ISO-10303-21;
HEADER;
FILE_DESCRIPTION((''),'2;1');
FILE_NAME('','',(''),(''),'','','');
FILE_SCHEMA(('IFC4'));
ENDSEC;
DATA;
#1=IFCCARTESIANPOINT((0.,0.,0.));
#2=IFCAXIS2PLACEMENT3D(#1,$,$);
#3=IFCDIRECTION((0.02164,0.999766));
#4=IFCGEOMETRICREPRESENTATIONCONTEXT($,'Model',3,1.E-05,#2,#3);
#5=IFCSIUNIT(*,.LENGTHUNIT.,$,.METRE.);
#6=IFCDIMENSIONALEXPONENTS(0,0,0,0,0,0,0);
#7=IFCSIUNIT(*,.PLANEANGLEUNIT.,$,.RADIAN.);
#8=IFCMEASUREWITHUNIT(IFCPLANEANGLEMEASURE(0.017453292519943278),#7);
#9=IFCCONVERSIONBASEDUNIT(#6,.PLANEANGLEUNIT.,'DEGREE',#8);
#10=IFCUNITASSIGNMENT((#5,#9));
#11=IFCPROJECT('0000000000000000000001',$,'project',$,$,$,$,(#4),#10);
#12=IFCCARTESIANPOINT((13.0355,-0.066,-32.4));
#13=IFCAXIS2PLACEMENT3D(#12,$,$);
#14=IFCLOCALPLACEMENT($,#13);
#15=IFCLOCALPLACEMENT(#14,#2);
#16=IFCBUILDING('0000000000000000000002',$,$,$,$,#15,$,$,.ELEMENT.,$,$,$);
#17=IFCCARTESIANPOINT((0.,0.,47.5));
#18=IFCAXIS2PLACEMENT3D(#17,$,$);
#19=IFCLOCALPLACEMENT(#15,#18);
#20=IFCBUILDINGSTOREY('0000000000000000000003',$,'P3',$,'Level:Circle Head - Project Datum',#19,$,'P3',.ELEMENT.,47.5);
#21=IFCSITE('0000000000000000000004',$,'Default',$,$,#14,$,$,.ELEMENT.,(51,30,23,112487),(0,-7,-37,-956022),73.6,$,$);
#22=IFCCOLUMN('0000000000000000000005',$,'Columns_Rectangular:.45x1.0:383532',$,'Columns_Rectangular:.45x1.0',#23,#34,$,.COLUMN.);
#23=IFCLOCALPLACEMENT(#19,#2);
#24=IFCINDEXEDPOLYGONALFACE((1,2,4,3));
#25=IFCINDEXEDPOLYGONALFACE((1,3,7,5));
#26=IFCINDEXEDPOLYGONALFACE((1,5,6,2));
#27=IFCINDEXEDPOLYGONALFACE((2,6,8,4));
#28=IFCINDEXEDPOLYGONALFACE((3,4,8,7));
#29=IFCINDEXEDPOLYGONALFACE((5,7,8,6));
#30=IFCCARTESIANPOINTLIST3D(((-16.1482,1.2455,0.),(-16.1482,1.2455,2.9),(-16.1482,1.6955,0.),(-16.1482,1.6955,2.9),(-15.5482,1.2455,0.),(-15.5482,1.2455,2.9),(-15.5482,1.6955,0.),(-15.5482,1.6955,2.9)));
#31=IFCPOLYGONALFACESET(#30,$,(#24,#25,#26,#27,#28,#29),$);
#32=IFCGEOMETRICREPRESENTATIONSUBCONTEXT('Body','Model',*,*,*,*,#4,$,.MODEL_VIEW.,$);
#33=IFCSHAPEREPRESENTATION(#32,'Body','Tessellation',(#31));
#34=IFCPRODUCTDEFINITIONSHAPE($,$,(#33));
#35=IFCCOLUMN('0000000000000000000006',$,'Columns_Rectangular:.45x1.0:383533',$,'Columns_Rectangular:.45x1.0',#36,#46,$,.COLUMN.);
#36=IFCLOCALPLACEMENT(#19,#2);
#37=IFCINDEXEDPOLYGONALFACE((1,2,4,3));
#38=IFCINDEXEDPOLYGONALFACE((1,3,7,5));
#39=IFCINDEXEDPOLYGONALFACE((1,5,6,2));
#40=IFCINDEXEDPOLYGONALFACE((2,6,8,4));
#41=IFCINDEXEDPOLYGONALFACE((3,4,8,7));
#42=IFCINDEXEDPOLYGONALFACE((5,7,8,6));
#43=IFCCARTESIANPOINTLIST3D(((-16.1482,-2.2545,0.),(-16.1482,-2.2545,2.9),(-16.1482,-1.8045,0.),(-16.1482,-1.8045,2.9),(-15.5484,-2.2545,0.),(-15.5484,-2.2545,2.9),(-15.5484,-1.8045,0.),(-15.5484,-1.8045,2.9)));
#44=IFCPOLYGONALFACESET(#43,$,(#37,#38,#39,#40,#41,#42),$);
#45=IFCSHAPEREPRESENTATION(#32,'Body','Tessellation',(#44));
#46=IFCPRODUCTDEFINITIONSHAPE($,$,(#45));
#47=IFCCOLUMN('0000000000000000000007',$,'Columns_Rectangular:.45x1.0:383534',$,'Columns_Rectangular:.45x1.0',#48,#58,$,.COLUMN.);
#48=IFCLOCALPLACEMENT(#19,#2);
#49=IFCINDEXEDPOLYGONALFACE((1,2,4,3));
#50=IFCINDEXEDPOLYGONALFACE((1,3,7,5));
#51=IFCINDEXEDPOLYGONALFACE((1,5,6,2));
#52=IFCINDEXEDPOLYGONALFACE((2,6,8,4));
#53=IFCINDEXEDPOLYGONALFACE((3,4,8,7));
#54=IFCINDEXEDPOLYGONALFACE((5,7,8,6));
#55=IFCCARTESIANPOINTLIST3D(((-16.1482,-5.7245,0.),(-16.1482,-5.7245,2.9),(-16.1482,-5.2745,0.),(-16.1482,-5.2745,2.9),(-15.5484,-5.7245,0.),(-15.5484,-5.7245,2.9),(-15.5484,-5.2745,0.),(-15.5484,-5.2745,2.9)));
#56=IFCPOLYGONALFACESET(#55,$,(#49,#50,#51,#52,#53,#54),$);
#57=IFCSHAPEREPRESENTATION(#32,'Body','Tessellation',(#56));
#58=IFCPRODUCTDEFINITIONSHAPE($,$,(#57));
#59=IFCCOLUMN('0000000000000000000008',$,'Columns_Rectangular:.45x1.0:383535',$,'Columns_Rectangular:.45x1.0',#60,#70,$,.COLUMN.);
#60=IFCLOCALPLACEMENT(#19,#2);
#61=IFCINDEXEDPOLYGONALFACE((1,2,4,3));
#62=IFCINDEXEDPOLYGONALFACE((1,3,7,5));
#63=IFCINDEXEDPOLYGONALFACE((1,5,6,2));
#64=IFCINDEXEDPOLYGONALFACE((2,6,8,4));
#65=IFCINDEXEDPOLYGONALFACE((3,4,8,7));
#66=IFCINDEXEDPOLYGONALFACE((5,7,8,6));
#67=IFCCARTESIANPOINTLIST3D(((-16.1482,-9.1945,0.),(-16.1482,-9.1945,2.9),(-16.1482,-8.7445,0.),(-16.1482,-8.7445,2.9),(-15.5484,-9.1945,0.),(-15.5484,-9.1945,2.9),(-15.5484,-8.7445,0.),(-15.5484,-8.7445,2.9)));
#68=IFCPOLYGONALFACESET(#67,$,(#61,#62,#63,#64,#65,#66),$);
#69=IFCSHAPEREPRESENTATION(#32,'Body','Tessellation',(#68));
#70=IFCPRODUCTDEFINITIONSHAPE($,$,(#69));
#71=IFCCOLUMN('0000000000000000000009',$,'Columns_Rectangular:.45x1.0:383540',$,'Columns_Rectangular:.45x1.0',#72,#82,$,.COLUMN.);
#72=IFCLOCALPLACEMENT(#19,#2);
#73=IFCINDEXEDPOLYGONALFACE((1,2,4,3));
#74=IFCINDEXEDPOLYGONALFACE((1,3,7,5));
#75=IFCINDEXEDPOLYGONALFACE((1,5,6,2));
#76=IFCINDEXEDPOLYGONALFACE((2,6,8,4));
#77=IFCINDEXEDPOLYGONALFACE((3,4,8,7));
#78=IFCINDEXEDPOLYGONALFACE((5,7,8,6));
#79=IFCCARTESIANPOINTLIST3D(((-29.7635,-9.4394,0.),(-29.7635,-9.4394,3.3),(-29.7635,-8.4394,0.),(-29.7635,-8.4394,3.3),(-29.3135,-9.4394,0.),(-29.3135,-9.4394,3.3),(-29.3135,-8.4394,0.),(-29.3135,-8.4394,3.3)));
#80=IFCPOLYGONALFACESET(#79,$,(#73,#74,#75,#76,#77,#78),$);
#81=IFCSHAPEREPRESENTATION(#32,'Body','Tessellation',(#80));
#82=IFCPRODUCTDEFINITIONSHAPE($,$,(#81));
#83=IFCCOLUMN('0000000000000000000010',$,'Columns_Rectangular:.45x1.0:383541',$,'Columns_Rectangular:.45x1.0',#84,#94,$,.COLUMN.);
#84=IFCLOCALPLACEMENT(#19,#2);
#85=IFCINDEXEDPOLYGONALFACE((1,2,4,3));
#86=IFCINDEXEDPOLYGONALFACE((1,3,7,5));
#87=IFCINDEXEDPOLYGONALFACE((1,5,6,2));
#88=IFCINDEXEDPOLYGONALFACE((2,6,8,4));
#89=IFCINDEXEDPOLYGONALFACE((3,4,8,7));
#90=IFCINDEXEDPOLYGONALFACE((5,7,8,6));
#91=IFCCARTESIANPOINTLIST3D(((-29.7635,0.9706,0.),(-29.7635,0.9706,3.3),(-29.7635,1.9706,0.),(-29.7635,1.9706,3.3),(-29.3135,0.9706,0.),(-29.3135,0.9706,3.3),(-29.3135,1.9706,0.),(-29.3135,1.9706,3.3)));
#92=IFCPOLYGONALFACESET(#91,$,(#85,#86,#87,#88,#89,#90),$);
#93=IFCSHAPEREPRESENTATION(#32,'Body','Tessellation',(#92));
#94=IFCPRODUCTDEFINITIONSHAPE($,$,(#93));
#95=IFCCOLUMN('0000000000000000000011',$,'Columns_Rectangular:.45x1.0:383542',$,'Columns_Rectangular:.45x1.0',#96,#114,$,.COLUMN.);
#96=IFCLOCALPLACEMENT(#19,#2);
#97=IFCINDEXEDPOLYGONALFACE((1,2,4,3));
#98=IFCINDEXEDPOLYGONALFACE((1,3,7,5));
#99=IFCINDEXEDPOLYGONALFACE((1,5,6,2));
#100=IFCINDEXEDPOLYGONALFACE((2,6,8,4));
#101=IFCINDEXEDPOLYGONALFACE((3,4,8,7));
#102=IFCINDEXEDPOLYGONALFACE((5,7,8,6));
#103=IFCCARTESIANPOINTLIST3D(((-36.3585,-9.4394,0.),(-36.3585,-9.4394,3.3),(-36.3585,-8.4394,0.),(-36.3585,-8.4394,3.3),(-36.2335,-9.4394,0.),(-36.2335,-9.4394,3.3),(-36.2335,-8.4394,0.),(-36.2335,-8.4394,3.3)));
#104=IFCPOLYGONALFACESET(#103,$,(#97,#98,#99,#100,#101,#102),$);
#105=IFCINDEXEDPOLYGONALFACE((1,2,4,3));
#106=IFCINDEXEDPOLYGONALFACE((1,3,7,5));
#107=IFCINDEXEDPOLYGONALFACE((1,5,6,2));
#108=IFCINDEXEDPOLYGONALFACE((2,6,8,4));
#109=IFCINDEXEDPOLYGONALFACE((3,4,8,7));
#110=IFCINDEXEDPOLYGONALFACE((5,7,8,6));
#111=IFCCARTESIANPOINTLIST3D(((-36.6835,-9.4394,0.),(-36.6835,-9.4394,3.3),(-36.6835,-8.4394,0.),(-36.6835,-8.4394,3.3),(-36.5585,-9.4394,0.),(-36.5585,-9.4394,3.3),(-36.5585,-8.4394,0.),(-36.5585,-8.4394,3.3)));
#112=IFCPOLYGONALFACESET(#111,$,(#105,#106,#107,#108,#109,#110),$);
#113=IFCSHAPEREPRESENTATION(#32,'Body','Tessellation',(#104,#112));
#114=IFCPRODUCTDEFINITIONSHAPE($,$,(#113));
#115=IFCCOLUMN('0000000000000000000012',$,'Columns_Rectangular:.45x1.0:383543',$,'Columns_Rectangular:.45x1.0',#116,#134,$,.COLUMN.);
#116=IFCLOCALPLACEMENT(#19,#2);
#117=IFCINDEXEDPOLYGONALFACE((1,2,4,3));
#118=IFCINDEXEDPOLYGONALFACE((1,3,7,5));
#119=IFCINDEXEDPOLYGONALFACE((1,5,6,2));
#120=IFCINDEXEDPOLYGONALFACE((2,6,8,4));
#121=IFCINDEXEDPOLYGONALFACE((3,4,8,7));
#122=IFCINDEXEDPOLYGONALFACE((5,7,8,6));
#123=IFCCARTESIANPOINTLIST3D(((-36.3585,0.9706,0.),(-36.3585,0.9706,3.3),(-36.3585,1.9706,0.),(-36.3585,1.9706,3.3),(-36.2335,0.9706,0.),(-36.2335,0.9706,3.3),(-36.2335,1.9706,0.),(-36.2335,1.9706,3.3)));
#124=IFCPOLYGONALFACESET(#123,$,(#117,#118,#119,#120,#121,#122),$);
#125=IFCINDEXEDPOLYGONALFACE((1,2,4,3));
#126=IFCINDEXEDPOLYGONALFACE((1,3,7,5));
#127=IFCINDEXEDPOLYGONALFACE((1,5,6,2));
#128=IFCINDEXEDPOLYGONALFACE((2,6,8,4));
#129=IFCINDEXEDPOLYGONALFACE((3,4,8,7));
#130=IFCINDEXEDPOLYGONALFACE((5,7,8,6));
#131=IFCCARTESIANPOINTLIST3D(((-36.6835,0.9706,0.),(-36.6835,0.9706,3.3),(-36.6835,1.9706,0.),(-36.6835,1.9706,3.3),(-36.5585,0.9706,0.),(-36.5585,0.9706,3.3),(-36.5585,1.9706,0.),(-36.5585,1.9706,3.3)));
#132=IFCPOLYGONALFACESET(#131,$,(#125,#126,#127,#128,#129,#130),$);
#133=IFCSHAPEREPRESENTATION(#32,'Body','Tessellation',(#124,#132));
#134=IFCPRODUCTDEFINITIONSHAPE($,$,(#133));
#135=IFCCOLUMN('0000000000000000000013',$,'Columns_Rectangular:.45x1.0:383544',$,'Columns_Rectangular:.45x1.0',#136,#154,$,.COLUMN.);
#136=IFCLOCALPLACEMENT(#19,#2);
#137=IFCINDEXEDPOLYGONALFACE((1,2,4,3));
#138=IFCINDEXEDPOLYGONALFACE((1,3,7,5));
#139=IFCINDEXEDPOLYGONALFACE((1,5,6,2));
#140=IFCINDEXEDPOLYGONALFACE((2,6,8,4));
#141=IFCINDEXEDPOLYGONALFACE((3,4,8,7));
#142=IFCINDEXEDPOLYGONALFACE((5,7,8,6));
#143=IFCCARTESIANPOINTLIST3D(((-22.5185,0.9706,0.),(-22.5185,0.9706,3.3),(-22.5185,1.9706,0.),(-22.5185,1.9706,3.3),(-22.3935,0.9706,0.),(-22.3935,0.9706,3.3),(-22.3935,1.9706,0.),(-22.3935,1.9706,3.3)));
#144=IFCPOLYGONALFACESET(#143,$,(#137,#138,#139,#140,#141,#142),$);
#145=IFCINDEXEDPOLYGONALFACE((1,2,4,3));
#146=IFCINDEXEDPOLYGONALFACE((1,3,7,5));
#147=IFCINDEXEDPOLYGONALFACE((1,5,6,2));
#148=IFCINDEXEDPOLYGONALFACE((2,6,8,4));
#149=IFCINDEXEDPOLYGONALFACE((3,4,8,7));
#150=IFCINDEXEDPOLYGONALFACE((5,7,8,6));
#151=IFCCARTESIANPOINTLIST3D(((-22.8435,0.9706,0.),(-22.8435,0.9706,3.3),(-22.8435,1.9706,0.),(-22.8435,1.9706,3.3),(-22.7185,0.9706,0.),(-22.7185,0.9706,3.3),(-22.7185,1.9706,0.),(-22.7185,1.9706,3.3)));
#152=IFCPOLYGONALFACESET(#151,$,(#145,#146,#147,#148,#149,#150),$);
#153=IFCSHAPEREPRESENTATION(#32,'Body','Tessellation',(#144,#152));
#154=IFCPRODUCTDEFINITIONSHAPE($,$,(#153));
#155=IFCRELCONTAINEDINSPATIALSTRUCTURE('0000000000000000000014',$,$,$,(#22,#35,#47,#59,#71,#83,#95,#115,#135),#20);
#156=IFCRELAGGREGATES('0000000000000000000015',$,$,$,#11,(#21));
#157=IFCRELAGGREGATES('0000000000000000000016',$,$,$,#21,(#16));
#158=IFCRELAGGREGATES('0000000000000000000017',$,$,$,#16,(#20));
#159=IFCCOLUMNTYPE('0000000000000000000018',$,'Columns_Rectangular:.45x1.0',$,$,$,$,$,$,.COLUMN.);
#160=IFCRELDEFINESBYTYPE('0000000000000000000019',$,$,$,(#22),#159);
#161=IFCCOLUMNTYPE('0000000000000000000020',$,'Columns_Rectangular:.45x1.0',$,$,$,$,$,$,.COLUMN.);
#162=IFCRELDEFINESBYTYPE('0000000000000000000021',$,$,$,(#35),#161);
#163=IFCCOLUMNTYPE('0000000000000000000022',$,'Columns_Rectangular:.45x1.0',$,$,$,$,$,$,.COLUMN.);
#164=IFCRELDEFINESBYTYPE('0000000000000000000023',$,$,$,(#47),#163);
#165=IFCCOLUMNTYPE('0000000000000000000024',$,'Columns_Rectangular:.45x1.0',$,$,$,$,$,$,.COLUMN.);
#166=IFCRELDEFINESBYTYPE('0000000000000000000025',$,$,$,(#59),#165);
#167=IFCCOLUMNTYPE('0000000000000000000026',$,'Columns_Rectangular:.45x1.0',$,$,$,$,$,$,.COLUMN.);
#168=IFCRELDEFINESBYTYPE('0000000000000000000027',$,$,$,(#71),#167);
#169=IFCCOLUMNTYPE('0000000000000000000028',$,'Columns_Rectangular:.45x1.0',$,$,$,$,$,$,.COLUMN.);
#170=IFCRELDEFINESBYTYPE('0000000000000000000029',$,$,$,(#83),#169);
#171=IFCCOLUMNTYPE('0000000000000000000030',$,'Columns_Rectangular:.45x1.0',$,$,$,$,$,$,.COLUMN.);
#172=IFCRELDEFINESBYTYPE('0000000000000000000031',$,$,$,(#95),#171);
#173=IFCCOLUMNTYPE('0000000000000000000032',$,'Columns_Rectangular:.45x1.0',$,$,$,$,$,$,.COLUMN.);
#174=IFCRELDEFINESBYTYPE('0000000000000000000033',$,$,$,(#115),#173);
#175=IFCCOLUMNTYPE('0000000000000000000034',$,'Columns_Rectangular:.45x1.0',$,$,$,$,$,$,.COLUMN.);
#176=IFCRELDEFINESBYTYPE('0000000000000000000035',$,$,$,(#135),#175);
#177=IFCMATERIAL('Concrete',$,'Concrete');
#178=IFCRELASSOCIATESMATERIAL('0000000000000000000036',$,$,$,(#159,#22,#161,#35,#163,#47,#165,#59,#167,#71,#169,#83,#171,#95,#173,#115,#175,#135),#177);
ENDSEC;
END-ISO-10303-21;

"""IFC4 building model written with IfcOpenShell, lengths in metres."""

from ifc_helpers import new_model, entity, si_unit, converted_unit, direction, frame, origin, place, context, subcontext, project, spatial, indexed_curve, outline, extrude, source, transform, mapped, material, type_object, type_shapes, element, save


model = new_model("IFC4")

# Units and contexts
model_context = context("Model", 3, precision=1e-05, world=origin(), true_north=direction((0.02164, 0.999766)))
body_context = subcontext(model_context, "Body", "Model", "MODEL_VIEW")
ifc_project = project(units=[si_unit("LENGTHUNIT", "METRE"), converted_unit("PLANEANGLEUNIT", "DEGREE", entity("IfcPlaneAngleMeasure", 0.017453292519943278), si_unit("PLANEANGLEUNIT", "RADIAN"), dimensions=[0, 0, 0, 0, 0, 0, 0])], contexts=[model_context])

# Site, building, storey
site_placement = place(None, frame((13.0355, -0.066, -32.4)))
site = spatial("IfcSite", under=ifc_project, at=site_placement, Name="Default", CompositionType="ELEMENT", RefLatitude=(51, 30, 23, 112487), RefLongitude=(0, -7, -37, -956022), RefElevation=73.6)
building_placement = place(site_placement, origin())
building = spatial("IfcBuilding", under=site, at=building_placement, CompositionType="ELEMENT")
storey_placement = place(building_placement, frame((0.0, 0.0, 47.5)))
storey = spatial("IfcBuildingStorey", under=building, at=storey_placement, Name="P3", ObjectType="Level:Circle Head - Project Datum", LongName="P3", CompositionType="ELEMENT", Elevation=47.5)

# Columns
ifc_material = material(Name="Concrete", Category="Concrete")
column_type_1 = type_object("IfcColumnType", Name="Columns_Rectangular:.45x1.0", PredefinedType="COLUMN", material=ifc_material)
shared_shape_1 = source(origin(), body_context, "Body", "SweptSolid", [
    extrude(outline(indexed_curve([(-0.3, -0.225), (0.3, -0.225), (0.3, 0.225), (-0.3, 0.225), (-0.3, -0.225)], self_intersect=False)), frame((-15.8482, 1.4705, 47.5), z_axis=(0.0, 0.0, 1.0), x_axis=(-1.0, 0.0, 0.0)), (0.0, 0.0, 1.0), 2.9),
])
type_shapes(column_type_1, [shared_shape_1])
column_1_placement = place(storey_placement, frame((0.0, 0.0, -47.5)))
element("IfcColumn", 1, at=column_1_placement, inside=storey, type_object=column_type_1, material=ifc_material, Name="Columns_Rectangular:.45x1.0:383532", ObjectType="Columns_Rectangular:.45x1.0", PredefinedType="COLUMN", context=body_context, shape_type="MappedRepresentation", body=[
    mapped(shared_shape_1, transform((0.0, 0.0, 0.0), scale=1.0)),
])
column_type_2 = type_object("IfcColumnType", Name="Columns_Rectangular:.45x1.0", PredefinedType="COLUMN", material=ifc_material)
shared_shape_2 = source(origin(), body_context, "Body", "SweptSolid", [
    extrude(outline(indexed_curve([(-0.2999, -0.225), (0.2999, -0.225), (0.2999, 0.225), (-0.2999, 0.225), (-0.2999, -0.225)], self_intersect=False)), frame((-15.8483, -2.0295, 47.5), z_axis=(0.0, 0.0, 1.0), x_axis=(-1.0, 0.0, 0.0)), (0.0, 0.0, 1.0), 2.9),
])
type_shapes(column_type_2, [shared_shape_2])
column_2_placement = place(storey_placement, frame((0.0, 0.0, -47.5)))
element("IfcColumn", 2, at=column_2_placement, inside=storey, type_object=column_type_2, material=ifc_material, Name="Columns_Rectangular:.45x1.0:383533", ObjectType="Columns_Rectangular:.45x1.0", PredefinedType="COLUMN", context=body_context, shape_type="MappedRepresentation", body=[
    mapped(shared_shape_2, transform((0.0, 0.0, 0.0), scale=1.0)),
])
column_type_3 = type_object("IfcColumnType", Name="Columns_Rectangular:.45x1.0", PredefinedType="COLUMN", material=ifc_material)
shared_shape_3 = source(origin(), body_context, "Body", "SweptSolid", [
    extrude(outline(indexed_curve([(-0.2999, -0.225), (0.2999, -0.225), (0.2999, 0.225), (-0.2999, 0.225), (-0.2999, -0.225)], self_intersect=False)), frame((-15.8483, -5.4995, 47.5), z_axis=(0.0, 0.0, 1.0), x_axis=(-1.0, 0.0, 0.0)), (0.0, 0.0, 1.0), 2.9),
])
type_shapes(column_type_3, [shared_shape_3])
column_3_placement = place(storey_placement, frame((0.0, 0.0, -47.5)))
element("IfcColumn", 3, at=column_3_placement, inside=storey, type_object=column_type_3, material=ifc_material, Name="Columns_Rectangular:.45x1.0:383534", ObjectType="Columns_Rectangular:.45x1.0", PredefinedType="COLUMN", context=body_context, shape_type="MappedRepresentation", body=[
    mapped(shared_shape_3, transform((0.0, 0.0, 0.0), scale=1.0)),
])
column_type_4 = type_object("IfcColumnType", Name="Columns_Rectangular:.45x1.0", PredefinedType="COLUMN", material=ifc_material)
shared_shape_4 = source(origin(), body_context, "Body", "SweptSolid", [
    extrude(outline(indexed_curve([(-0.2999, -0.225), (0.2999, -0.225), (0.2999, 0.225), (-0.2999, 0.225), (-0.2999, -0.225)], self_intersect=False)), frame((-15.8483, -8.9695, 47.5), z_axis=(0.0, 0.0, 1.0), x_axis=(-1.0, 0.0, 0.0)), (0.0, 0.0, 1.0), 2.9),
])
type_shapes(column_type_4, [shared_shape_4])
column_4_placement = place(storey_placement, frame((0.0, 0.0, -47.5)))
element("IfcColumn", 4, at=column_4_placement, inside=storey, type_object=column_type_4, material=ifc_material, Name="Columns_Rectangular:.45x1.0:383535", ObjectType="Columns_Rectangular:.45x1.0", PredefinedType="COLUMN", context=body_context, shape_type="MappedRepresentation", body=[
    mapped(shared_shape_4, transform((0.0, 0.0, 0.0), scale=1.0)),
])
column_type_5 = type_object("IfcColumnType", Name="Columns_Rectangular:.45x1.0", PredefinedType="COLUMN", material=ifc_material)
shared_shape_5 = source(origin(), body_context, "Body", "SweptSolid", [
    extrude(outline(indexed_curve([(-0.5, -0.225), (0.5, -0.225), (0.5, 0.225), (-0.5, 0.225), (-0.5, -0.225)], self_intersect=False)), frame((-29.5385, -8.9394, 47.5), z_axis=(0.0, 0.0, 1.0), x_axis=(0.0, 1.0, 0.0)), (0.0, 0.0, 1.0), 3.3),
])
type_shapes(column_type_5, [shared_shape_5])
column_5_placement = place(storey_placement, frame((0.0, 0.0, -47.5)))
element("IfcColumn", 5, at=column_5_placement, inside=storey, type_object=column_type_5, material=ifc_material, Name="Columns_Rectangular:.45x1.0:383540", ObjectType="Columns_Rectangular:.45x1.0", PredefinedType="COLUMN", context=body_context, shape_type="MappedRepresentation", body=[
    mapped(shared_shape_5, transform((0.0, 0.0, 0.0), scale=1.0)),
])
column_type_6 = type_object("IfcColumnType", Name="Columns_Rectangular:.45x1.0", PredefinedType="COLUMN", material=ifc_material)
shared_shape_6 = source(origin(), body_context, "Body", "SweptSolid", [
    extrude(outline(indexed_curve([(-0.5, -0.225), (0.5, -0.225), (0.5, 0.225), (-0.5, 0.225), (-0.5, -0.225)], self_intersect=False)), frame((-29.5385, 1.4706, 47.5), z_axis=(0.0, 0.0, 1.0), x_axis=(0.0, 1.0, 0.0)), (0.0, 0.0, 1.0), 3.3),
])
type_shapes(column_type_6, [shared_shape_6])
column_6_placement = place(storey_placement, frame((0.0, 0.0, -47.5)))
element("IfcColumn", 6, at=column_6_placement, inside=storey, type_object=column_type_6, material=ifc_material, Name="Columns_Rectangular:.45x1.0:383541", ObjectType="Columns_Rectangular:.45x1.0", PredefinedType="COLUMN", context=body_context, shape_type="MappedRepresentation", body=[
    mapped(shared_shape_6, transform((0.0, 0.0, 0.0), scale=1.0)),
])
column_type_7 = type_object("IfcColumnType", Name="Columns_Rectangular:.45x1.0", PredefinedType="COLUMN", material=ifc_material)
shared_shape_7 = source(origin(), body_context, "Body", "SweptSolid", [
    extrude(outline(indexed_curve([(-0.0625, -0.5), (0.0625, -0.5), (0.0625, 0.5), (-0.0625, 0.5), (-0.0625, -0.5)], self_intersect=False)), frame((-36.296, -8.9394, 47.5), z_axis=(0.0, 0.0, 1.0), x_axis=(-1.0, 0.0, 0.0)), (0.0, 0.0, 1.0), 3.3),
    extrude(outline(indexed_curve([(-0.0625, -0.5), (0.0625, -0.5), (0.0625, 0.5), (-0.0625, 0.5), (-0.0625, -0.5)], self_intersect=False)), frame((-36.621, -8.9394, 47.5)), (0.0, 0.0, 1.0), 3.3),
])
type_shapes(column_type_7, [shared_shape_7])
column_7_placement = place(storey_placement, frame((0.0, 0.0, -47.5)))
element("IfcColumn", 7, at=column_7_placement, inside=storey, type_object=column_type_7, material=ifc_material, Name="Columns_Rectangular:.45x1.0:383542", ObjectType="Columns_Rectangular:.45x1.0", PredefinedType="COLUMN", context=body_context, shape_type="MappedRepresentation", body=[
    mapped(shared_shape_7, transform((0.0, 0.0, 0.0), scale=1.0)),
])
column_type_8 = type_object("IfcColumnType", Name="Columns_Rectangular:.45x1.0", PredefinedType="COLUMN", material=ifc_material)
shared_shape_8 = source(origin(), body_context, "Body", "SweptSolid", [
    extrude(outline(indexed_curve([(-0.0625, -0.5), (0.0625, -0.5), (0.0625, 0.5), (-0.0625, 0.5), (-0.0625, -0.5)], self_intersect=False)), frame((-36.296, 1.4706, 47.5), z_axis=(0.0, 0.0, 1.0), x_axis=(-1.0, 0.0, 0.0)), (0.0, 0.0, 1.0), 3.3),
    extrude(outline(indexed_curve([(-0.0625, -0.5), (0.0625, -0.5), (0.0625, 0.5), (-0.0625, 0.5), (-0.0625, -0.5)], self_intersect=False)), frame((-36.621, 1.4706, 47.5)), (0.0, 0.0, 1.0), 3.3),
])
type_shapes(column_type_8, [shared_shape_8])
column_8_placement = place(storey_placement, frame((0.0, 0.0, -47.5)))
element("IfcColumn", 8, at=column_8_placement, inside=storey, type_object=column_type_8, material=ifc_material, Name="Columns_Rectangular:.45x1.0:383543", ObjectType="Columns_Rectangular:.45x1.0", PredefinedType="COLUMN", context=body_context, shape_type="MappedRepresentation", body=[
    mapped(shared_shape_8, transform((0.0, 0.0, 0.0), scale=1.0)),
])
column_type_9 = type_object("IfcColumnType", Name="Columns_Rectangular:.45x1.0", PredefinedType="COLUMN", material=ifc_material)
shared_shape_9 = source(origin(), body_context, "Body", "SweptSolid", [
    extrude(outline(indexed_curve([(-0.0625, -0.5), (0.0625, -0.5), (0.0625, 0.5), (-0.0625, 0.5), (-0.0625, -0.5)], self_intersect=False)), frame((-22.456, 1.4706, 47.5), z_axis=(0.0, 0.0, 1.0), x_axis=(-1.0, 0.0, 0.0)), (0.0, 0.0, 1.0), 3.3),
    extrude(outline(indexed_curve([(-0.0625, -0.5), (0.0625, -0.5), (0.0625, 0.5), (-0.0625, 0.5), (-0.0625, -0.5)], self_intersect=False)), frame((-22.781, 1.4706, 47.5)), (0.0, 0.0, 1.0), 3.3),
])
type_shapes(column_type_9, [shared_shape_9])
column_9_placement = place(storey_placement, frame((0.0, 0.0, -47.5)))
element("IfcColumn", 9, at=column_9_placement, inside=storey, type_object=column_type_9, material=ifc_material, Name="Columns_Rectangular:.45x1.0:383544", ObjectType="Columns_Rectangular:.45x1.0", PredefinedType="COLUMN", context=body_context, shape_type="MappedRepresentation", body=[
    mapped(shared_shape_9, transform((0.0, 0.0, 0.0), scale=1.0)),
])

save(model, "model.ifc")
